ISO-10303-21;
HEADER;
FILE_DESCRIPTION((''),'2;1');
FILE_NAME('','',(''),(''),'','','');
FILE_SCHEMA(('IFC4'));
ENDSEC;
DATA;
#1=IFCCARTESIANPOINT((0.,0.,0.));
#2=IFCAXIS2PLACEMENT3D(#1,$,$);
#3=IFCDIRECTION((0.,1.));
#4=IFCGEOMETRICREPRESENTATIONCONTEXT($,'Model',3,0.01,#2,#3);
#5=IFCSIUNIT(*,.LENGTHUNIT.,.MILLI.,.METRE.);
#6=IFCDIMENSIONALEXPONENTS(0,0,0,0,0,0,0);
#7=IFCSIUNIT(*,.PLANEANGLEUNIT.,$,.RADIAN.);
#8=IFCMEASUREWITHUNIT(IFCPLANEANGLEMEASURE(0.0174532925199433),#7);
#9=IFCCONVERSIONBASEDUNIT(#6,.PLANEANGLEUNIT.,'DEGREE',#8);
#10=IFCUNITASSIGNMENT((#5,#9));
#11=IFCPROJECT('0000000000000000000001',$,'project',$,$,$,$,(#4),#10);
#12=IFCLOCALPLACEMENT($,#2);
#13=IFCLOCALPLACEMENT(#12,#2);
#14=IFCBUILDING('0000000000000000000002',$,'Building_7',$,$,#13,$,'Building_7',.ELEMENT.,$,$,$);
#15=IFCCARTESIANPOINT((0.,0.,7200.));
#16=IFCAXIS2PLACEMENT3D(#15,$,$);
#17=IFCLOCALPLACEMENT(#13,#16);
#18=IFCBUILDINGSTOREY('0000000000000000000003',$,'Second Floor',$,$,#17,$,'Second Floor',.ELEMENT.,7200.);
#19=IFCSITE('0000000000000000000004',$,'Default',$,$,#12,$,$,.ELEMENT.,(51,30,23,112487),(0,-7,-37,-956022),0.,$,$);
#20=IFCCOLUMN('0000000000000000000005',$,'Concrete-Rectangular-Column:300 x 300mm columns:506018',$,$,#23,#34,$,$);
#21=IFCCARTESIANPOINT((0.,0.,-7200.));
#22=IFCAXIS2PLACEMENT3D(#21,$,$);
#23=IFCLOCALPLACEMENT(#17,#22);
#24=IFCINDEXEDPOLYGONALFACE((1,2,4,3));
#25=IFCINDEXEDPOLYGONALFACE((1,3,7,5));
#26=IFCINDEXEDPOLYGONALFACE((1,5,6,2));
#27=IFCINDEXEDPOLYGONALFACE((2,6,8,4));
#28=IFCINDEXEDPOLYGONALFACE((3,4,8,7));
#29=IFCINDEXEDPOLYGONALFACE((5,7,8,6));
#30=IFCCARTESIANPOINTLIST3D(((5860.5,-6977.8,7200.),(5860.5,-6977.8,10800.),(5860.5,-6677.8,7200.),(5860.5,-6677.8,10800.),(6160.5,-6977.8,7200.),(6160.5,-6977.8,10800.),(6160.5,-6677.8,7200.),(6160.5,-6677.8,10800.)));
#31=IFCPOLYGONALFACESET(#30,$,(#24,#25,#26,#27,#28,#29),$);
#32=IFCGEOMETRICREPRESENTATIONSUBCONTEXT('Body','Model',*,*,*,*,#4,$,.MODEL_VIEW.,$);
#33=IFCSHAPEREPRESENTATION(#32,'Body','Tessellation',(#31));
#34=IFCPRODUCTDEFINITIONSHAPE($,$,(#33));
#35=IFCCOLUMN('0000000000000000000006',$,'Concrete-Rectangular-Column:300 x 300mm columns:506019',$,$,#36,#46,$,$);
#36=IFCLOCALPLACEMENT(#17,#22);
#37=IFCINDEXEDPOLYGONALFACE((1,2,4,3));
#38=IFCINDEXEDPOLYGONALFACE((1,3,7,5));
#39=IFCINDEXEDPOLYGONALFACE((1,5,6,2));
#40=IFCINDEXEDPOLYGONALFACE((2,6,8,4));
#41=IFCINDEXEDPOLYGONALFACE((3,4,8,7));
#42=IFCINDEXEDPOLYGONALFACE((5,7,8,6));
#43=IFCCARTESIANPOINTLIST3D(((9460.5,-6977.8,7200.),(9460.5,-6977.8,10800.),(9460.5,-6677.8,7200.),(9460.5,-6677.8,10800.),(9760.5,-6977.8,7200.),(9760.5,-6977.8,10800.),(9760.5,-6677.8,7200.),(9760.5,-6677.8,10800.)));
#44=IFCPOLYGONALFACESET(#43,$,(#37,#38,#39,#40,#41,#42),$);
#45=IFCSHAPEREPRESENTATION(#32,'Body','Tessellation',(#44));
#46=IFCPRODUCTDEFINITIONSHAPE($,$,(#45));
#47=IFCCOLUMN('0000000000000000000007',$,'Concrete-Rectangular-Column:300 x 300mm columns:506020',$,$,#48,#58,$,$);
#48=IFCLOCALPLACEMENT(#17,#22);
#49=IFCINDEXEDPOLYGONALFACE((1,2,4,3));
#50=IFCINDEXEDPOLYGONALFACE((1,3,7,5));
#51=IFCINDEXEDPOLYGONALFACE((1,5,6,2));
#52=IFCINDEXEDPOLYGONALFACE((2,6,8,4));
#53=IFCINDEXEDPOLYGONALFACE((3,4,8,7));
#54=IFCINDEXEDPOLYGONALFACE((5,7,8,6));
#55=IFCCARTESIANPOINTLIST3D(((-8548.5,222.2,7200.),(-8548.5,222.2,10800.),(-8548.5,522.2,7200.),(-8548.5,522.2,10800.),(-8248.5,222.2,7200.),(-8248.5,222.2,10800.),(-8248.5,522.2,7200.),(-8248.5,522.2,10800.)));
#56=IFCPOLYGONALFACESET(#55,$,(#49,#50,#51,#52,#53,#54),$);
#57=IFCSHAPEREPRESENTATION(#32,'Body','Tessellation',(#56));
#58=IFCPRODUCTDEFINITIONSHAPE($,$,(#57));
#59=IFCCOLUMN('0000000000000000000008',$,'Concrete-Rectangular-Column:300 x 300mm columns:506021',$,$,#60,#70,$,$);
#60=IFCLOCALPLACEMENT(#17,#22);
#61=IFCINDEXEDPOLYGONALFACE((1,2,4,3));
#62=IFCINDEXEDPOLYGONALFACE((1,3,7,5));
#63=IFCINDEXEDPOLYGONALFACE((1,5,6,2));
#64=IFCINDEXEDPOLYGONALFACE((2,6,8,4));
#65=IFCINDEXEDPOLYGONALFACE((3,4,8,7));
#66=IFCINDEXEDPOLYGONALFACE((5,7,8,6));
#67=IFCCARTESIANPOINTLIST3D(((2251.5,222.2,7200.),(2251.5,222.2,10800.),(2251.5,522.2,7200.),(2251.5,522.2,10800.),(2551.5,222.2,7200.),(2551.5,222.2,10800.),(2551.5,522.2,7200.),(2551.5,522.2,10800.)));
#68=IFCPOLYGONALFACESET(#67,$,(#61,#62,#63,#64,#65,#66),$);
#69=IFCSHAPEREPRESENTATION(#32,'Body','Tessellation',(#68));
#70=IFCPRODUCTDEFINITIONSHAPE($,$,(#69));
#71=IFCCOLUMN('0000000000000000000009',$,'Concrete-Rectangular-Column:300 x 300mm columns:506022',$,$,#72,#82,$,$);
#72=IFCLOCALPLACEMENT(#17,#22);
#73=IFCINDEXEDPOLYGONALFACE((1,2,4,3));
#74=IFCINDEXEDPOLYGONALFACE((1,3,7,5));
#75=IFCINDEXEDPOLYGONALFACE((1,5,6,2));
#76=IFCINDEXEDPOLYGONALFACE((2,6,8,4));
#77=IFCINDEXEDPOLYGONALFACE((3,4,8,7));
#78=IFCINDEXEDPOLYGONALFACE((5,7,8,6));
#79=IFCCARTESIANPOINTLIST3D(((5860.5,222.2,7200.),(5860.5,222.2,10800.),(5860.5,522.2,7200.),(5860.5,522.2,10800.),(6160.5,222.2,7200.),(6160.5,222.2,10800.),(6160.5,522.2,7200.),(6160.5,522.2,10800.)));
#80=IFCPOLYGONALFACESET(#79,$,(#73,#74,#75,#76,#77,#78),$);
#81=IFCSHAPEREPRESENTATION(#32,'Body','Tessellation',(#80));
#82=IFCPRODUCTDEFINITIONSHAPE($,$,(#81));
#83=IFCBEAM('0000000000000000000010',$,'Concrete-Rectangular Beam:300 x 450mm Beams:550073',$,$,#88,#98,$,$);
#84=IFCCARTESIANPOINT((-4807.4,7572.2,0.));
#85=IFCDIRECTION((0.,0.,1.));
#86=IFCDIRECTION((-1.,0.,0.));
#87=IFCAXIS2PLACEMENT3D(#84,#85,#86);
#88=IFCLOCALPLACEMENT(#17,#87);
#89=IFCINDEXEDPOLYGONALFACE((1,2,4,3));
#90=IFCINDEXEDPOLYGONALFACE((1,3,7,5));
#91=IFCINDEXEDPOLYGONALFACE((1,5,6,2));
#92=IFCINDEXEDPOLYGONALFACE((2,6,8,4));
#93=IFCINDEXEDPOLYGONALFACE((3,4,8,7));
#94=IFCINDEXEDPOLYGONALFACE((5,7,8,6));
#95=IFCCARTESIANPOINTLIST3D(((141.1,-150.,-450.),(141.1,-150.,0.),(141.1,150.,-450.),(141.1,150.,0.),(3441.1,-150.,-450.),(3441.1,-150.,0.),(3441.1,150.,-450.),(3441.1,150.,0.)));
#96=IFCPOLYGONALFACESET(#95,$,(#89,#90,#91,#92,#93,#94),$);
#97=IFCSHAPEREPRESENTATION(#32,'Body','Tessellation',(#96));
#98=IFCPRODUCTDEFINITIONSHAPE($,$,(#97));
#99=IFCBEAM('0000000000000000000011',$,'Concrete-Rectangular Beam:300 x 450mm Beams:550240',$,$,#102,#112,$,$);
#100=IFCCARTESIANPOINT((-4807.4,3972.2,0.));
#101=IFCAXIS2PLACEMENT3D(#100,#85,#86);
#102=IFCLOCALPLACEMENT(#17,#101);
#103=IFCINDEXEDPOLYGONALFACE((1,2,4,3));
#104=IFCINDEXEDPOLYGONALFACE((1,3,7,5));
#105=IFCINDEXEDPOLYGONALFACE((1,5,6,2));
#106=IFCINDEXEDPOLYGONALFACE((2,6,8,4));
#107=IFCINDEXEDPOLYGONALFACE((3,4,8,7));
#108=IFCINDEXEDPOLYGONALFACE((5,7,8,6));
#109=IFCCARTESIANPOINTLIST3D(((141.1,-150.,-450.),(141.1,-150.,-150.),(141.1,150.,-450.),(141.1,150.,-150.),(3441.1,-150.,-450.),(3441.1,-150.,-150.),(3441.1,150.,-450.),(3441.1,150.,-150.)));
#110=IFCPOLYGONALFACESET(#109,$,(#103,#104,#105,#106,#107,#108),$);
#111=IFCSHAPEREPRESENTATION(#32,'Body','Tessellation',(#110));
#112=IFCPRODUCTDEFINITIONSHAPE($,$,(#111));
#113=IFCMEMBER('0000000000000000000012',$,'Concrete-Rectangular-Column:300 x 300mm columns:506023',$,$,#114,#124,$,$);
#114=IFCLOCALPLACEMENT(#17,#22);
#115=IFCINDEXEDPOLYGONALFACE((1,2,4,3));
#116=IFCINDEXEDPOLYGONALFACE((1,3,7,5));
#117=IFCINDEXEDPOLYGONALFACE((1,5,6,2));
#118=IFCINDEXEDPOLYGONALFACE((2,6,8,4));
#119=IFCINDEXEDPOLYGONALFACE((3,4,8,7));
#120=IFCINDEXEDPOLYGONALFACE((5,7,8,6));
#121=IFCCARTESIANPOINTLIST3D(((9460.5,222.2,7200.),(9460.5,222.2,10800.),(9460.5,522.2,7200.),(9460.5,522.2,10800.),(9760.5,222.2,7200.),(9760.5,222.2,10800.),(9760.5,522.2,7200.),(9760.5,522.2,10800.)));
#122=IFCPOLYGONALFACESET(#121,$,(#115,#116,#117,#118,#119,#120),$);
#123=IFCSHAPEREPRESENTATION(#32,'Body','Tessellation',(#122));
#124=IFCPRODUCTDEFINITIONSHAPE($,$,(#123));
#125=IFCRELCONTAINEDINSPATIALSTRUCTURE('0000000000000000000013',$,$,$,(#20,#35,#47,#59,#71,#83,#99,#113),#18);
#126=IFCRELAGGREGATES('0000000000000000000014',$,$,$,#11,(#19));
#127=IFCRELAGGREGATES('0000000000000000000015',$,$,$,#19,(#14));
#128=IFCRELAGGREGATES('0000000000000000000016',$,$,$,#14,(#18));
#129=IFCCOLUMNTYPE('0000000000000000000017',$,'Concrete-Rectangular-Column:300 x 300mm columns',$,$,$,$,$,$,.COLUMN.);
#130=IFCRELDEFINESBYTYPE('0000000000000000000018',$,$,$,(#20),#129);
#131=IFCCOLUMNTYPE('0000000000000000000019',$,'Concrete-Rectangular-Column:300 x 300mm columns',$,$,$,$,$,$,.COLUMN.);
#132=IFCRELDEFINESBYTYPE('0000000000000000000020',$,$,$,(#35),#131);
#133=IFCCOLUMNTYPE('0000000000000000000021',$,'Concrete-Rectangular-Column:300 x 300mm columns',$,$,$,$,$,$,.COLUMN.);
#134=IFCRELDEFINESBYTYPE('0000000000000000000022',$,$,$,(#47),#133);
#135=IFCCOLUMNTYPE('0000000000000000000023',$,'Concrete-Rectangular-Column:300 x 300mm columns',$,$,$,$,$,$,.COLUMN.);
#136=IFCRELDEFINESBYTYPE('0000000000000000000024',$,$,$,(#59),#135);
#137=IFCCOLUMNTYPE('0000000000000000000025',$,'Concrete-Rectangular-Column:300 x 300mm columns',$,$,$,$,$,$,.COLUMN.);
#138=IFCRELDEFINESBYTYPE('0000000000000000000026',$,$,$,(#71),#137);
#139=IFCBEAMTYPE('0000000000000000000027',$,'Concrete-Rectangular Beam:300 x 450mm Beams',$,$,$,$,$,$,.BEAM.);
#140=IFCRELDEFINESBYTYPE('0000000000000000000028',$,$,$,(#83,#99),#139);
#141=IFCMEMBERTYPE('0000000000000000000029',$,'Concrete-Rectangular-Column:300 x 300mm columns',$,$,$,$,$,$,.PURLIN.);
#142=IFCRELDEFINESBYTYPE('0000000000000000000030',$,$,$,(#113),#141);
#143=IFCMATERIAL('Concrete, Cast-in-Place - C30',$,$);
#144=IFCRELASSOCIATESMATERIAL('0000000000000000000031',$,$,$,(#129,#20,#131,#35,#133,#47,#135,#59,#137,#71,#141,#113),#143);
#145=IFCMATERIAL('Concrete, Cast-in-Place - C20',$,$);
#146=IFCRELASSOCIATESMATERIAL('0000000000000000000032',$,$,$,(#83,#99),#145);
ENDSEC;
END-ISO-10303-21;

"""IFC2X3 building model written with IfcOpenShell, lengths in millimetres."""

from ifc_helpers import new_model, entity, si_unit, converted_unit, direction, frame, frame_2d, origin, origin_2d_with_axis, place, context, subcontext, project, spatial, rectangle, extrude, source, transform, mapped, material, type_object, type_shapes, element, save


model = new_model("IFC2X3")

# Units and contexts
model_context = context("Model", 3, precision=0.01, world=origin(), true_north=direction((0.0, 1.0)))
body_context = subcontext(model_context, "Body", "Model", "MODEL_VIEW")
ifc_project = project(units=[si_unit("LENGTHUNIT", "METRE", prefix="MILLI"), converted_unit("PLANEANGLEUNIT", "DEGREE", entity("IfcPlaneAngleMeasure", 0.0174532925199433), si_unit("PLANEANGLEUNIT", "RADIAN"), dimensions=[0, 0, 0, 0, 0, 0, 0])], contexts=[model_context])

# Site, building, storey
site_placement = place(None, origin())
site = spatial("IfcSite", under=ifc_project, at=site_placement, Name="Default", CompositionType="ELEMENT", RefLatitude=(51, 30, 23, 112487), RefLongitude=(0, -7, -37, -956022), RefElevation=0.0)
building_placement = place(site_placement, origin())
building = spatial("IfcBuilding", under=site, at=building_placement, Name="Building_7", LongName="Building_7", CompositionType="ELEMENT")
storey_placement = place(building_placement, frame((0.0, 0.0, 7200.0)))
storey = spatial("IfcBuildingStorey", under=building, at=storey_placement, Name="Second Floor", LongName="Second Floor", CompositionType="ELEMENT", Elevation=7200.0)

# Columns
ifc_material_1 = material(Name="Concrete, Cast-in-Place - C30")
column_type_1 = type_object("IfcColumnType", Name="Concrete-Rectangular-Column:300 x 300mm columns", PredefinedType="COLUMN", material=ifc_material_1)
shared_shape_1 = source(origin(), body_context, "Body", "SweptSolid", [
    extrude(rectangle(XDim=300.0, YDim=300.0, at=frame_2d((0.0, 0.0), x_axis=(1.0, 0.0))), frame((6010.5, -6827.8, 7200.0), z_axis=(0.0, 0.0, 1.0), x_axis=(-1.0, 0.0, 0.0)), (0.0, 0.0, 1.0), 3600.0),
])
type_shapes(column_type_1, [shared_shape_1])
column_1_placement = place(storey_placement, frame((0.0, 0.0, -7200.0)))
element("IfcColumn", 1, at=column_1_placement, inside=storey, type_object=column_type_1, material=ifc_material_1, Name="Concrete-Rectangular-Column:300 x 300mm columns:506018", context=body_context, shape_type="MappedRepresentation", body=[
    mapped(shared_shape_1, transform((0.0, 0.0, 0.0), scale=1.0)),
])
column_type_2 = type_object("IfcColumnType", Name="Concrete-Rectangular-Column:300 x 300mm columns", PredefinedType="COLUMN", material=ifc_material_1)
shared_shape_2 = source(origin(), body_context, "Body", "SweptSolid", [
    extrude(rectangle(XDim=300.0, YDim=300.0, at=frame_2d((0.0, 0.0), x_axis=(1.0, 0.0))), frame((9610.5, -6827.8, 7200.0), z_axis=(0.0, 0.0, 1.0), x_axis=(-1.0, 0.0, 0.0)), (0.0, 0.0, 1.0), 3600.0),
])
type_shapes(column_type_2, [shared_shape_2])
column_2_placement = place(storey_placement, frame((0.0, 0.0, -7200.0)))
element("IfcColumn", 2, at=column_2_placement, inside=storey, type_object=column_type_2, material=ifc_material_1, Name="Concrete-Rectangular-Column:300 x 300mm columns:506019", context=body_context, shape_type="MappedRepresentation", body=[
    mapped(shared_shape_2, transform((0.0, 0.0, 0.0), scale=1.0)),
])
column_type_3 = type_object("IfcColumnType", Name="Concrete-Rectangular-Column:300 x 300mm columns", PredefinedType="COLUMN", material=ifc_material_1)
shared_shape_3 = source(origin(), body_context, "Body", "SweptSolid", [
    extrude(rectangle(XDim=300.0, YDim=300.0, at=frame_2d((0.0, 0.0), x_axis=(1.0, 0.0))), frame((-8398.5, 372.2, 7200.0), z_axis=(0.0, 0.0, 1.0), x_axis=(-1.0, 0.0, 0.0)), (0.0, 0.0, 1.0), 3600.0),
])
type_shapes(column_type_3, [shared_shape_3])
column_3_placement = place(storey_placement, frame((0.0, 0.0, -7200.0)))
element("IfcColumn", 3, at=column_3_placement, inside=storey, type_object=column_type_3, material=ifc_material_1, Name="Concrete-Rectangular-Column:300 x 300mm columns:506020", context=body_context, shape_type="MappedRepresentation", body=[
    mapped(shared_shape_3, transform((0.0, 0.0, 0.0), scale=1.0)),
])
column_type_4 = type_object("IfcColumnType", Name="Concrete-Rectangular-Column:300 x 300mm columns", PredefinedType="COLUMN", material=ifc_material_1)
shared_shape_4 = source(origin(), body_context, "Body", "SweptSolid", [
    extrude(rectangle(XDim=300.0, YDim=300.0, at=frame_2d((0.0, 0.0), x_axis=(1.0, 0.0))), frame((2401.5, 372.2, 7200.0), z_axis=(0.0, 0.0, 1.0), x_axis=(-1.0, 0.0, 0.0)), (0.0, 0.0, 1.0), 3600.0),
])
type_shapes(column_type_4, [shared_shape_4])
column_4_placement = place(storey_placement, frame((0.0, 0.0, -7200.0)))
element("IfcColumn", 4, at=column_4_placement, inside=storey, type_object=column_type_4, material=ifc_material_1, Name="Concrete-Rectangular-Column:300 x 300mm columns:506021", context=body_context, shape_type="MappedRepresentation", body=[
    mapped(shared_shape_4, transform((0.0, 0.0, 0.0), scale=1.0)),
])
column_type_5 = type_object("IfcColumnType", Name="Concrete-Rectangular-Column:300 x 300mm columns", PredefinedType="COLUMN", material=ifc_material_1)
shared_shape_5 = source(origin(), body_context, "Body", "SweptSolid", [
    extrude(rectangle(XDim=300.0, YDim=300.0, at=frame_2d((0.0, 0.0), x_axis=(1.0, 0.0))), frame((6010.5, 372.2, 7200.0), z_axis=(0.0, 0.0, 1.0), x_axis=(-1.0, 0.0, 0.0)), (0.0, 0.0, 1.0), 3600.0),
])
type_shapes(column_type_5, [shared_shape_5])
column_5_placement = place(storey_placement, frame((0.0, 0.0, -7200.0)))
element("IfcColumn", 5, at=column_5_placement, inside=storey, type_object=column_type_5, material=ifc_material_1, Name="Concrete-Rectangular-Column:300 x 300mm columns:506022", context=body_context, shape_type="MappedRepresentation", body=[
    mapped(shared_shape_5, transform((0.0, 0.0, 0.0), scale=1.0)),
])

# Beams
ifc_material_2 = material(Name="Concrete, Cast-in-Place - C20")
beam_type_1 = type_object("IfcBeamType", Name="Concrete-Rectangular Beam:300 x 450mm Beams", PredefinedType="BEAM")
beam_1_placement = place(storey_placement, frame((-4807.4, 7572.2, 0.0), z_axis=(0.0, 0.0, 1.0), x_axis=(-1.0, 0.0, 0.0)))
element("IfcBeam", 6, at=beam_1_placement, inside=storey, type_object=beam_type_1, material=ifc_material_2, Name="Concrete-Rectangular Beam:300 x 450mm Beams:550073", context=body_context, shape_type="SweptSolid", body=[
    extrude(rectangle(XDim=450.0, YDim=300.0, at=origin_2d_with_axis()), frame((141.1, 0.0, -225.0), z_axis=(1.0, 0.0, 0.0), x_axis=(0.0, 0.0, -1.0)), (0.0, 0.0, 1.0), 3300.0),
])
beam_2_placement = place(storey_placement, frame((-4807.4, 3972.2, 0.0), z_axis=(0.0, 0.0, 1.0), x_axis=(-1.0, 0.0, 0.0)))
element("IfcBeam", 7, at=beam_2_placement, inside=storey, type_object=beam_type_1, material=ifc_material_2, Name="Concrete-Rectangular Beam:300 x 450mm Beams:550240", context=body_context, shape_type="SweptSolid", body=[
    extrude(rectangle(XDim=300.0, YDim=300.0, at=frame_2d((0.0, 0.0), x_axis=(1.0, 0.0))), frame((141.1, 0.0, -300.0), z_axis=(1.0, 0.0, 0.0), x_axis=(0.0, 0.0, -1.0)), (0.0, 0.0, 1.0), 3300.0),
])

# Member
member_type = type_object("IfcMemberType", Name="Concrete-Rectangular-Column:300 x 300mm columns", PredefinedType="PURLIN", material=ifc_material_1)
shared_shape_6 = source(origin(), body_context, "Body", "SweptSolid", [
    extrude(rectangle(XDim=300.0, YDim=300.0, at=frame_2d((0.0, 0.0), x_axis=(1.0, 0.0))), frame((9610.5, 372.2, 7200.0), z_axis=(0.0, 0.0, 1.0), x_axis=(-1.0, 0.0, 0.0)), (0.0, 0.0, 1.0), 3600.0),
])
type_shapes(member_type, [shared_shape_6])
member_placement = place(storey_placement, frame((0.0, 0.0, -7200.0)))
element("IfcMember", 8, at=member_placement, inside=storey, type_object=member_type, material=ifc_material_1, Name="Concrete-Rectangular-Column:300 x 300mm columns:506023", context=body_context, shape_type="MappedRepresentation", body=[
    mapped(shared_shape_6, transform((0.0, 0.0, 0.0), scale=1.0)),
])

save(model, "model.ifc")
